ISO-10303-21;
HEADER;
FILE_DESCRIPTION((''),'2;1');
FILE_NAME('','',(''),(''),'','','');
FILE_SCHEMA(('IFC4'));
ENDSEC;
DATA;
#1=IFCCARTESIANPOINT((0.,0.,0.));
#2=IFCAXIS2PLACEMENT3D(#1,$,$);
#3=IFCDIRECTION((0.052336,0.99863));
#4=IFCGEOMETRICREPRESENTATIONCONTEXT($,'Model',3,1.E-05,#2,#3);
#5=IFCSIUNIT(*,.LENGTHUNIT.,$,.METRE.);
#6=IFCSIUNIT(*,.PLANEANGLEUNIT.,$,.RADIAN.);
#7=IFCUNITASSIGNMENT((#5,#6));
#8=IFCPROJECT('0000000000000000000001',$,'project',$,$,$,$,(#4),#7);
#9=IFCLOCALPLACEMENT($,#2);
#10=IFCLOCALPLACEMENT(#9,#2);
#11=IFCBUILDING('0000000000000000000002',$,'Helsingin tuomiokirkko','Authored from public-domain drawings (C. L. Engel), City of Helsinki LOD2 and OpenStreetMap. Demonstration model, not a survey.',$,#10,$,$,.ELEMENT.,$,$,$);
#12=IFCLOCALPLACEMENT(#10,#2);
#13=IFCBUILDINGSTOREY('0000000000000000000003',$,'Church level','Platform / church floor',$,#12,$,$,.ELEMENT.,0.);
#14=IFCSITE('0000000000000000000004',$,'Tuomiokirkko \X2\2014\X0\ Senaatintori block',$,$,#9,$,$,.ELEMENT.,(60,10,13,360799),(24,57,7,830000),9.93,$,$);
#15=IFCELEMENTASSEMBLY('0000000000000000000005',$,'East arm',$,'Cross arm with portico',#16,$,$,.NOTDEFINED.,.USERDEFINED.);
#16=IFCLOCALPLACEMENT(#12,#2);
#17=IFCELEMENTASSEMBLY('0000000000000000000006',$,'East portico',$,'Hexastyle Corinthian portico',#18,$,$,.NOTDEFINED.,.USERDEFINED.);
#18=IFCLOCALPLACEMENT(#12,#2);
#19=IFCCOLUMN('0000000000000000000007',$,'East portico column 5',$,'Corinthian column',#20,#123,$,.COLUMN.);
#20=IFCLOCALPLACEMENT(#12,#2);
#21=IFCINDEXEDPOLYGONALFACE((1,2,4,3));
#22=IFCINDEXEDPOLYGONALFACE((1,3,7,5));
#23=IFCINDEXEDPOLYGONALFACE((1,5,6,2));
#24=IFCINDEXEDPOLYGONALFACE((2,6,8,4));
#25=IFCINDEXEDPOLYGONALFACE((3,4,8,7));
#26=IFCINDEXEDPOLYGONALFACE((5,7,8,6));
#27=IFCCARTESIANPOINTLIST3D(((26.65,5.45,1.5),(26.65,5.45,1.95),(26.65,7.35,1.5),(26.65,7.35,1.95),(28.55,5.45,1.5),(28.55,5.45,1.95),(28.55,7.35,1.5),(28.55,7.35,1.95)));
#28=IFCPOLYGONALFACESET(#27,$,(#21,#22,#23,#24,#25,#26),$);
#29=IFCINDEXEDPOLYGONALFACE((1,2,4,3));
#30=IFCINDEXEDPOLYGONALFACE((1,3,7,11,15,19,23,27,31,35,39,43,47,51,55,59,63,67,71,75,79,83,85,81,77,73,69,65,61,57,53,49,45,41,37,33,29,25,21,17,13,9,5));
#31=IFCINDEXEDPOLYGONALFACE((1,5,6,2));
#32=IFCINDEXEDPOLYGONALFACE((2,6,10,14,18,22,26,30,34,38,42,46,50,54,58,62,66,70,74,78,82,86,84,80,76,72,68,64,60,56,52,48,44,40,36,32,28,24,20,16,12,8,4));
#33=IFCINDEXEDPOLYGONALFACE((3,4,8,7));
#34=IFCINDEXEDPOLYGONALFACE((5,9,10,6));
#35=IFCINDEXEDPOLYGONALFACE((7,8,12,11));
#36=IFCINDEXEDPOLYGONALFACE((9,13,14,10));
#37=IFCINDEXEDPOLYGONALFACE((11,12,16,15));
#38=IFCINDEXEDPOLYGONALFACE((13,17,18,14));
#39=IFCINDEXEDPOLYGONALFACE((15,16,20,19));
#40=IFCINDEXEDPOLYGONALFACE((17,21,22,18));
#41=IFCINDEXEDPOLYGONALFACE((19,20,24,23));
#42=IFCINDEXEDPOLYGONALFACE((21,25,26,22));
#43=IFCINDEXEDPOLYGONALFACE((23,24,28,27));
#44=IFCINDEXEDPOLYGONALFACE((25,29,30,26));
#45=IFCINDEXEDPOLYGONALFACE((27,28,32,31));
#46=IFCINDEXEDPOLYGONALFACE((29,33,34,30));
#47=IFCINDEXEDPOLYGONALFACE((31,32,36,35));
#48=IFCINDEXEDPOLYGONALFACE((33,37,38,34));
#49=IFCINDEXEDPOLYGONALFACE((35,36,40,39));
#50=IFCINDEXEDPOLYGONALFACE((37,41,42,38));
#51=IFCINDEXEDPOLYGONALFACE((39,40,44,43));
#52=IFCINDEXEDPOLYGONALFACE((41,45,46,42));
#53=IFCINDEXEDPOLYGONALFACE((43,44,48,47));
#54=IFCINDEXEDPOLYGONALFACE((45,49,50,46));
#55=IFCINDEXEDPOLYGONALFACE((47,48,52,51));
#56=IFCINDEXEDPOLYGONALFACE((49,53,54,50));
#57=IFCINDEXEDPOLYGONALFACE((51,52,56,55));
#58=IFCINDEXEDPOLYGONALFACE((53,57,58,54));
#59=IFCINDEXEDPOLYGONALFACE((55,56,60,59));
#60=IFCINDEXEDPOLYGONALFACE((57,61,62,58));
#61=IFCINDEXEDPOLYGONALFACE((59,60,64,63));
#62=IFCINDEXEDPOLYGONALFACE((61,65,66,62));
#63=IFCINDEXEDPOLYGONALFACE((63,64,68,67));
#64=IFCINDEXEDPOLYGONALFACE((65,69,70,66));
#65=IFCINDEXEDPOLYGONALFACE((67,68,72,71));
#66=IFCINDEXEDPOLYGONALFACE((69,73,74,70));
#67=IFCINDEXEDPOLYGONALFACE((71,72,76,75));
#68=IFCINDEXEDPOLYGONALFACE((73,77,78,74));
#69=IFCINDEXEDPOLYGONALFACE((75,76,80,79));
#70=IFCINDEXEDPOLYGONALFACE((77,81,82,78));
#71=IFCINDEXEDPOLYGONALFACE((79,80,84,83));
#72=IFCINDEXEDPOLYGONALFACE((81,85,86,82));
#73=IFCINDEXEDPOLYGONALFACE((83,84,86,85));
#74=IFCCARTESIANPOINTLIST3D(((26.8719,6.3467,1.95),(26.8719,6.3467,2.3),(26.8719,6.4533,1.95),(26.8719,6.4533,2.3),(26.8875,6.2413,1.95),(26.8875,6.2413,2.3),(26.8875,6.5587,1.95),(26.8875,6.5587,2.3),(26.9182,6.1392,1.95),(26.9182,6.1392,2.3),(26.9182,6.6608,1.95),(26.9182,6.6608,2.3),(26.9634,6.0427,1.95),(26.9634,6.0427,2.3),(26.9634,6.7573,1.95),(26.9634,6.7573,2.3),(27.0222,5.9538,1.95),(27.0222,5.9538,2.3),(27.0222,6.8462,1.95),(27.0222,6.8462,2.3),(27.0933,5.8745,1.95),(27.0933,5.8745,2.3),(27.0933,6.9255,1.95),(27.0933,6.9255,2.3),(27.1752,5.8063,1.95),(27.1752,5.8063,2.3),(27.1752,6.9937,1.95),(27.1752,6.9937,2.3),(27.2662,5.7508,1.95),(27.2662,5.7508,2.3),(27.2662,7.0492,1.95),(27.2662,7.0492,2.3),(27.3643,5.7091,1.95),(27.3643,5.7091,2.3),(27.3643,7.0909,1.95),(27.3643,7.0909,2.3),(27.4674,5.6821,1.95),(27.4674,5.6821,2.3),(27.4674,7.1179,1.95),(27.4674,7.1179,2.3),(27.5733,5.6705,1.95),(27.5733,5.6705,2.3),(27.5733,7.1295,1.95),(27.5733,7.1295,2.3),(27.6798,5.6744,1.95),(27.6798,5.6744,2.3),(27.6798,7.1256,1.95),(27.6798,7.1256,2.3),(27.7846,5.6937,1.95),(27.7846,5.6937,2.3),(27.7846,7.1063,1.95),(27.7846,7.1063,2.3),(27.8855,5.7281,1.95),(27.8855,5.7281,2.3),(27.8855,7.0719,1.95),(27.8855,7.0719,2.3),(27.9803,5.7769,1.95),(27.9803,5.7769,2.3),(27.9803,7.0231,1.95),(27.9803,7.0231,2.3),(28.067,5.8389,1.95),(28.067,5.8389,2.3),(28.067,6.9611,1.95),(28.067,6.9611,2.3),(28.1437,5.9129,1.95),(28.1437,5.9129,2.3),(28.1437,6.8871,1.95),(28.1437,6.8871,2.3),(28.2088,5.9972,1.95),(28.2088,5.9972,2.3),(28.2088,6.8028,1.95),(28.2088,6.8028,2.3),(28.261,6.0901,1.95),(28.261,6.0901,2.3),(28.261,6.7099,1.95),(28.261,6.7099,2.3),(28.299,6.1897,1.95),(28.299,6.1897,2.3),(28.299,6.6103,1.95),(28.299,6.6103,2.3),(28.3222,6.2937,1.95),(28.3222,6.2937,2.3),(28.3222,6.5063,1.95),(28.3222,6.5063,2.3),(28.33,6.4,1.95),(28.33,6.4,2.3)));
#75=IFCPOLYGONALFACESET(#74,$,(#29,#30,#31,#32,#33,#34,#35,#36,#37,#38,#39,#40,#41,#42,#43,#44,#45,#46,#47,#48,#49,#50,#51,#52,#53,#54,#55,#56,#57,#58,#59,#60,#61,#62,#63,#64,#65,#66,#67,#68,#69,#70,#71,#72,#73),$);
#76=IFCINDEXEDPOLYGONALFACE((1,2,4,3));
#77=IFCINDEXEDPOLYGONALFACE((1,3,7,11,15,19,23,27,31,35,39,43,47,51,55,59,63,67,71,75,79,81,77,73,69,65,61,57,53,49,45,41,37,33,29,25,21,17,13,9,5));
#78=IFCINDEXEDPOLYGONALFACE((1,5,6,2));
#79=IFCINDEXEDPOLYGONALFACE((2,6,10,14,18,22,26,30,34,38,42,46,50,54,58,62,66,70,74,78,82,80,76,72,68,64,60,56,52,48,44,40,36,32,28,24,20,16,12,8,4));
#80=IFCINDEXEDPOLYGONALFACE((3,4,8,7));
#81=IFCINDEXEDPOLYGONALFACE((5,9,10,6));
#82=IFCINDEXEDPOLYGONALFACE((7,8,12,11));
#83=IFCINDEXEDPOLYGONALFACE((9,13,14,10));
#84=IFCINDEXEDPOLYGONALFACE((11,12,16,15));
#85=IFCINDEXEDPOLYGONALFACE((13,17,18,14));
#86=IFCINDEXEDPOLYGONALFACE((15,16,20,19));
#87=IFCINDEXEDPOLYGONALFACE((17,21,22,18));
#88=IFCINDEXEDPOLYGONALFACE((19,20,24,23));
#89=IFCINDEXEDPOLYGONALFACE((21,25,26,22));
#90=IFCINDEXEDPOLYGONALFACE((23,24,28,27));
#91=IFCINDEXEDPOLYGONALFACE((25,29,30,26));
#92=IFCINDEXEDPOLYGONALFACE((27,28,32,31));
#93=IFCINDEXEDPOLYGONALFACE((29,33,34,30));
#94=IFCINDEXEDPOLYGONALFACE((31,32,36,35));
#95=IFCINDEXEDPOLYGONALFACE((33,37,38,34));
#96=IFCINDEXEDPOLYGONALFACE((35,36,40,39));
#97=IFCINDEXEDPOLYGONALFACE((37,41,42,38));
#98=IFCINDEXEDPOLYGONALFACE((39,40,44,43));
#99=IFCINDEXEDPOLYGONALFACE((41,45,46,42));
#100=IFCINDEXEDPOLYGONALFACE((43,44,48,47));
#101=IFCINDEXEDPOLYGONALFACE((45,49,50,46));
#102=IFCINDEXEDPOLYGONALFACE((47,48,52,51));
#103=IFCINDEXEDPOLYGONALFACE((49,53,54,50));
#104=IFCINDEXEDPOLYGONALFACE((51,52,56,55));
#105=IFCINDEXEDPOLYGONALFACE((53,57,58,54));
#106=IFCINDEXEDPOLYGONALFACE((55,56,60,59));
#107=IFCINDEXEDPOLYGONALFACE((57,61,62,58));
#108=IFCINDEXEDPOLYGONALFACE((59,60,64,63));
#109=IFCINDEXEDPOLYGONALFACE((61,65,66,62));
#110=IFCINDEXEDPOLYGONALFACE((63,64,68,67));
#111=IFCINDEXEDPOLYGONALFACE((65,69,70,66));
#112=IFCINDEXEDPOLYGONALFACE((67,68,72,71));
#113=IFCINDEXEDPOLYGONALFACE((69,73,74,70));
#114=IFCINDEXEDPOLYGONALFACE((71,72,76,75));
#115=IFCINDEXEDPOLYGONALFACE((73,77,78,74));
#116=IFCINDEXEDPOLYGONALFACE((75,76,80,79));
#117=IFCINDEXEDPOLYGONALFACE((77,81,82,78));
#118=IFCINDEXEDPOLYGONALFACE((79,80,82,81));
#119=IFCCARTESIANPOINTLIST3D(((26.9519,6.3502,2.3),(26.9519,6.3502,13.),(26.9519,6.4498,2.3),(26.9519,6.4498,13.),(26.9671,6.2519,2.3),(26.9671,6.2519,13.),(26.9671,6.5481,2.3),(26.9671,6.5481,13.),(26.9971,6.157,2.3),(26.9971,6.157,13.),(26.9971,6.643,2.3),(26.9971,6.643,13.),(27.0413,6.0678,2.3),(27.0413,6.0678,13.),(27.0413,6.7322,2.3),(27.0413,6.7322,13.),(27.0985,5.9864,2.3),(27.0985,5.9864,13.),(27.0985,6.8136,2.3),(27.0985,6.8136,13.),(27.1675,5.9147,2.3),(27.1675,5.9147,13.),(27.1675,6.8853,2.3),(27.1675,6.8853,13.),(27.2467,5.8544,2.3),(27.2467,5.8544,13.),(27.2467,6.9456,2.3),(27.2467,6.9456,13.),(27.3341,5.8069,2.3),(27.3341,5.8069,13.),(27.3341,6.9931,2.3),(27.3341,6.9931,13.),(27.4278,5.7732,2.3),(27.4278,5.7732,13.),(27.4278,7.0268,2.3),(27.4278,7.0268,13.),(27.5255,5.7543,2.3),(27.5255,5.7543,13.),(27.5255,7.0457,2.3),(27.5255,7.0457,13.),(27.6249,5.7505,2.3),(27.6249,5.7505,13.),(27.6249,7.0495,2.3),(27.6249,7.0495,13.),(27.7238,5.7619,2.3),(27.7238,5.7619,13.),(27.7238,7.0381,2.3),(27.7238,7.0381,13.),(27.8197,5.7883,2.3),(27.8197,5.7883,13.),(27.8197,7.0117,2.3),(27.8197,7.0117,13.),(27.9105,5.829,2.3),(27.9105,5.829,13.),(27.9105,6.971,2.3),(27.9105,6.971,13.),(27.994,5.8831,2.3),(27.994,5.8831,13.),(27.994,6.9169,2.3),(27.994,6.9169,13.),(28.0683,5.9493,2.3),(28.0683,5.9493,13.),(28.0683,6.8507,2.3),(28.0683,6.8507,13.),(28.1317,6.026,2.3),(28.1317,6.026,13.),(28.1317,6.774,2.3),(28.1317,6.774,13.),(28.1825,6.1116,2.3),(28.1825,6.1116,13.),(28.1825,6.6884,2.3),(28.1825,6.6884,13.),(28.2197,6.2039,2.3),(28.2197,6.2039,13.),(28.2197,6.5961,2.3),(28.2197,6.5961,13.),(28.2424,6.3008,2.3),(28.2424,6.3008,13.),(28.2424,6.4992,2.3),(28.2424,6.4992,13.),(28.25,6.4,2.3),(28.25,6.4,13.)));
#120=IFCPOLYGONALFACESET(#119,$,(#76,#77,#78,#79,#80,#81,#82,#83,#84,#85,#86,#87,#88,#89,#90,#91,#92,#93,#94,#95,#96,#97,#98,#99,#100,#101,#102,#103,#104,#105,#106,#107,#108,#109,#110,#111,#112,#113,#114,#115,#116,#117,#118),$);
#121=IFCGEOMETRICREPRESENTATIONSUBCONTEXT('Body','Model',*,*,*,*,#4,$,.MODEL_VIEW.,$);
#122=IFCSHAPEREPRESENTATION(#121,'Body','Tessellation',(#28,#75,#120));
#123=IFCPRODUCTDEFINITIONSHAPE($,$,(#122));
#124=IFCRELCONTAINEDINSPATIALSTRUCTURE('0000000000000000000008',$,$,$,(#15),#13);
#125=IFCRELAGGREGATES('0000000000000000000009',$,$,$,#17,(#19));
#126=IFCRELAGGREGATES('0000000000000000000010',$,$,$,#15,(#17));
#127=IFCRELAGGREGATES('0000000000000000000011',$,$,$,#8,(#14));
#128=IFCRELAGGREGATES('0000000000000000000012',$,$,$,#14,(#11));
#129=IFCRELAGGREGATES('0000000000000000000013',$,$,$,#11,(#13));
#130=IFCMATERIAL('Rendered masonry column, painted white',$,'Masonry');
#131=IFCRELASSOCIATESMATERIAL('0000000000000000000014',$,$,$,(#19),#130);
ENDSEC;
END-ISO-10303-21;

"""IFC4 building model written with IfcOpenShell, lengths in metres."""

from ifc_helpers import new_model, si_unit, direction, frame, origin, origin_2d_with_axis, place, context, subcontext, project, spatial, rectangle, circle, extrude, material, element, aggregate, save


model = new_model("IFC4")

# Units and contexts
model_context = context("Model", 3, precision=1e-05, world=origin(), true_north=direction((0.052336, 0.99863)))
body_context = subcontext(model_context, "Body", "Model", "MODEL_VIEW")
ifc_project = project(units=[si_unit("LENGTHUNIT", "METRE"), si_unit("PLANEANGLEUNIT", "RADIAN")], contexts=[model_context])

# Site, building, storey
site_placement = place(None, origin())
site = spatial("IfcSite", under=ifc_project, at=site_placement, Name="Tuomiokirkko — Senaatintori block", CompositionType="ELEMENT", RefLatitude=(60, 10, 13, 360799), RefLongitude=(24, 57, 7, 830000), RefElevation=9.93)
building_placement = place(site_placement, origin())
building = spatial("IfcBuilding", under=site, at=building_placement, Name="Helsingin tuomiokirkko", Description="Authored from public-domain drawings (C. L. Engel), City of Helsinki LOD2 and OpenStreetMap. Demonstration model, not a survey.", CompositionType="ELEMENT")
storey_placement = place(building_placement, origin())
storey = spatial("IfcBuildingStorey", under=building, at=storey_placement, Name="Church level", Description="Platform / church floor", CompositionType="ELEMENT", Elevation=0.0)

# Shared definitions
ifc_material_1 = material(Name="Rendered masonry column, painted white", Category="Masonry")

# Element assemblies, column
assembly_1_placement = place(building_placement, origin())
assembly_1 = element("IfcElementAssembly", 1, at=assembly_1_placement, inside=storey, Name="East arm", ObjectType="Cross arm with portico", AssemblyPlace="NOTDEFINED", PredefinedType="USERDEFINED")
assembly_2_placement = place(building_placement, origin())
assembly_2 = element("IfcElementAssembly", 2, at=assembly_2_placement, Name="East portico", ObjectType="Hexastyle Corinthian portico", AssemblyPlace="NOTDEFINED", PredefinedType="USERDEFINED")
column_1_placement = place(building_placement, origin())
column_1 = element("IfcColumn", 3, at=column_1_placement, material=ifc_material_1, Name="East portico column 5", ObjectType="Corinthian column", PredefinedType="COLUMN", context=body_context, shape_type="SweptSolid", body=[
    extrude(rectangle(XDim=1.9, YDim=1.9, at=origin_2d_with_axis()), frame((27.6, 6.4, 1.5)), (0.0, 0.0, 1.0), 0.45),
    extrude(circle(Radius=0.73, at=origin_2d_with_axis()), frame((27.6, 6.4, 1.95)), (0.0, 0.0, 1.0), 0.35),
    extrude(circle(Radius=0.65, at=origin_2d_with_axis()), frame((27.6, 6.4, 2.3)), (0.0, 0.0, 1.0), 10.7),
])

aggregate(assembly_2, [column_1])

aggregate(assembly_1, [assembly_2])

save(model, "model.ifc")
